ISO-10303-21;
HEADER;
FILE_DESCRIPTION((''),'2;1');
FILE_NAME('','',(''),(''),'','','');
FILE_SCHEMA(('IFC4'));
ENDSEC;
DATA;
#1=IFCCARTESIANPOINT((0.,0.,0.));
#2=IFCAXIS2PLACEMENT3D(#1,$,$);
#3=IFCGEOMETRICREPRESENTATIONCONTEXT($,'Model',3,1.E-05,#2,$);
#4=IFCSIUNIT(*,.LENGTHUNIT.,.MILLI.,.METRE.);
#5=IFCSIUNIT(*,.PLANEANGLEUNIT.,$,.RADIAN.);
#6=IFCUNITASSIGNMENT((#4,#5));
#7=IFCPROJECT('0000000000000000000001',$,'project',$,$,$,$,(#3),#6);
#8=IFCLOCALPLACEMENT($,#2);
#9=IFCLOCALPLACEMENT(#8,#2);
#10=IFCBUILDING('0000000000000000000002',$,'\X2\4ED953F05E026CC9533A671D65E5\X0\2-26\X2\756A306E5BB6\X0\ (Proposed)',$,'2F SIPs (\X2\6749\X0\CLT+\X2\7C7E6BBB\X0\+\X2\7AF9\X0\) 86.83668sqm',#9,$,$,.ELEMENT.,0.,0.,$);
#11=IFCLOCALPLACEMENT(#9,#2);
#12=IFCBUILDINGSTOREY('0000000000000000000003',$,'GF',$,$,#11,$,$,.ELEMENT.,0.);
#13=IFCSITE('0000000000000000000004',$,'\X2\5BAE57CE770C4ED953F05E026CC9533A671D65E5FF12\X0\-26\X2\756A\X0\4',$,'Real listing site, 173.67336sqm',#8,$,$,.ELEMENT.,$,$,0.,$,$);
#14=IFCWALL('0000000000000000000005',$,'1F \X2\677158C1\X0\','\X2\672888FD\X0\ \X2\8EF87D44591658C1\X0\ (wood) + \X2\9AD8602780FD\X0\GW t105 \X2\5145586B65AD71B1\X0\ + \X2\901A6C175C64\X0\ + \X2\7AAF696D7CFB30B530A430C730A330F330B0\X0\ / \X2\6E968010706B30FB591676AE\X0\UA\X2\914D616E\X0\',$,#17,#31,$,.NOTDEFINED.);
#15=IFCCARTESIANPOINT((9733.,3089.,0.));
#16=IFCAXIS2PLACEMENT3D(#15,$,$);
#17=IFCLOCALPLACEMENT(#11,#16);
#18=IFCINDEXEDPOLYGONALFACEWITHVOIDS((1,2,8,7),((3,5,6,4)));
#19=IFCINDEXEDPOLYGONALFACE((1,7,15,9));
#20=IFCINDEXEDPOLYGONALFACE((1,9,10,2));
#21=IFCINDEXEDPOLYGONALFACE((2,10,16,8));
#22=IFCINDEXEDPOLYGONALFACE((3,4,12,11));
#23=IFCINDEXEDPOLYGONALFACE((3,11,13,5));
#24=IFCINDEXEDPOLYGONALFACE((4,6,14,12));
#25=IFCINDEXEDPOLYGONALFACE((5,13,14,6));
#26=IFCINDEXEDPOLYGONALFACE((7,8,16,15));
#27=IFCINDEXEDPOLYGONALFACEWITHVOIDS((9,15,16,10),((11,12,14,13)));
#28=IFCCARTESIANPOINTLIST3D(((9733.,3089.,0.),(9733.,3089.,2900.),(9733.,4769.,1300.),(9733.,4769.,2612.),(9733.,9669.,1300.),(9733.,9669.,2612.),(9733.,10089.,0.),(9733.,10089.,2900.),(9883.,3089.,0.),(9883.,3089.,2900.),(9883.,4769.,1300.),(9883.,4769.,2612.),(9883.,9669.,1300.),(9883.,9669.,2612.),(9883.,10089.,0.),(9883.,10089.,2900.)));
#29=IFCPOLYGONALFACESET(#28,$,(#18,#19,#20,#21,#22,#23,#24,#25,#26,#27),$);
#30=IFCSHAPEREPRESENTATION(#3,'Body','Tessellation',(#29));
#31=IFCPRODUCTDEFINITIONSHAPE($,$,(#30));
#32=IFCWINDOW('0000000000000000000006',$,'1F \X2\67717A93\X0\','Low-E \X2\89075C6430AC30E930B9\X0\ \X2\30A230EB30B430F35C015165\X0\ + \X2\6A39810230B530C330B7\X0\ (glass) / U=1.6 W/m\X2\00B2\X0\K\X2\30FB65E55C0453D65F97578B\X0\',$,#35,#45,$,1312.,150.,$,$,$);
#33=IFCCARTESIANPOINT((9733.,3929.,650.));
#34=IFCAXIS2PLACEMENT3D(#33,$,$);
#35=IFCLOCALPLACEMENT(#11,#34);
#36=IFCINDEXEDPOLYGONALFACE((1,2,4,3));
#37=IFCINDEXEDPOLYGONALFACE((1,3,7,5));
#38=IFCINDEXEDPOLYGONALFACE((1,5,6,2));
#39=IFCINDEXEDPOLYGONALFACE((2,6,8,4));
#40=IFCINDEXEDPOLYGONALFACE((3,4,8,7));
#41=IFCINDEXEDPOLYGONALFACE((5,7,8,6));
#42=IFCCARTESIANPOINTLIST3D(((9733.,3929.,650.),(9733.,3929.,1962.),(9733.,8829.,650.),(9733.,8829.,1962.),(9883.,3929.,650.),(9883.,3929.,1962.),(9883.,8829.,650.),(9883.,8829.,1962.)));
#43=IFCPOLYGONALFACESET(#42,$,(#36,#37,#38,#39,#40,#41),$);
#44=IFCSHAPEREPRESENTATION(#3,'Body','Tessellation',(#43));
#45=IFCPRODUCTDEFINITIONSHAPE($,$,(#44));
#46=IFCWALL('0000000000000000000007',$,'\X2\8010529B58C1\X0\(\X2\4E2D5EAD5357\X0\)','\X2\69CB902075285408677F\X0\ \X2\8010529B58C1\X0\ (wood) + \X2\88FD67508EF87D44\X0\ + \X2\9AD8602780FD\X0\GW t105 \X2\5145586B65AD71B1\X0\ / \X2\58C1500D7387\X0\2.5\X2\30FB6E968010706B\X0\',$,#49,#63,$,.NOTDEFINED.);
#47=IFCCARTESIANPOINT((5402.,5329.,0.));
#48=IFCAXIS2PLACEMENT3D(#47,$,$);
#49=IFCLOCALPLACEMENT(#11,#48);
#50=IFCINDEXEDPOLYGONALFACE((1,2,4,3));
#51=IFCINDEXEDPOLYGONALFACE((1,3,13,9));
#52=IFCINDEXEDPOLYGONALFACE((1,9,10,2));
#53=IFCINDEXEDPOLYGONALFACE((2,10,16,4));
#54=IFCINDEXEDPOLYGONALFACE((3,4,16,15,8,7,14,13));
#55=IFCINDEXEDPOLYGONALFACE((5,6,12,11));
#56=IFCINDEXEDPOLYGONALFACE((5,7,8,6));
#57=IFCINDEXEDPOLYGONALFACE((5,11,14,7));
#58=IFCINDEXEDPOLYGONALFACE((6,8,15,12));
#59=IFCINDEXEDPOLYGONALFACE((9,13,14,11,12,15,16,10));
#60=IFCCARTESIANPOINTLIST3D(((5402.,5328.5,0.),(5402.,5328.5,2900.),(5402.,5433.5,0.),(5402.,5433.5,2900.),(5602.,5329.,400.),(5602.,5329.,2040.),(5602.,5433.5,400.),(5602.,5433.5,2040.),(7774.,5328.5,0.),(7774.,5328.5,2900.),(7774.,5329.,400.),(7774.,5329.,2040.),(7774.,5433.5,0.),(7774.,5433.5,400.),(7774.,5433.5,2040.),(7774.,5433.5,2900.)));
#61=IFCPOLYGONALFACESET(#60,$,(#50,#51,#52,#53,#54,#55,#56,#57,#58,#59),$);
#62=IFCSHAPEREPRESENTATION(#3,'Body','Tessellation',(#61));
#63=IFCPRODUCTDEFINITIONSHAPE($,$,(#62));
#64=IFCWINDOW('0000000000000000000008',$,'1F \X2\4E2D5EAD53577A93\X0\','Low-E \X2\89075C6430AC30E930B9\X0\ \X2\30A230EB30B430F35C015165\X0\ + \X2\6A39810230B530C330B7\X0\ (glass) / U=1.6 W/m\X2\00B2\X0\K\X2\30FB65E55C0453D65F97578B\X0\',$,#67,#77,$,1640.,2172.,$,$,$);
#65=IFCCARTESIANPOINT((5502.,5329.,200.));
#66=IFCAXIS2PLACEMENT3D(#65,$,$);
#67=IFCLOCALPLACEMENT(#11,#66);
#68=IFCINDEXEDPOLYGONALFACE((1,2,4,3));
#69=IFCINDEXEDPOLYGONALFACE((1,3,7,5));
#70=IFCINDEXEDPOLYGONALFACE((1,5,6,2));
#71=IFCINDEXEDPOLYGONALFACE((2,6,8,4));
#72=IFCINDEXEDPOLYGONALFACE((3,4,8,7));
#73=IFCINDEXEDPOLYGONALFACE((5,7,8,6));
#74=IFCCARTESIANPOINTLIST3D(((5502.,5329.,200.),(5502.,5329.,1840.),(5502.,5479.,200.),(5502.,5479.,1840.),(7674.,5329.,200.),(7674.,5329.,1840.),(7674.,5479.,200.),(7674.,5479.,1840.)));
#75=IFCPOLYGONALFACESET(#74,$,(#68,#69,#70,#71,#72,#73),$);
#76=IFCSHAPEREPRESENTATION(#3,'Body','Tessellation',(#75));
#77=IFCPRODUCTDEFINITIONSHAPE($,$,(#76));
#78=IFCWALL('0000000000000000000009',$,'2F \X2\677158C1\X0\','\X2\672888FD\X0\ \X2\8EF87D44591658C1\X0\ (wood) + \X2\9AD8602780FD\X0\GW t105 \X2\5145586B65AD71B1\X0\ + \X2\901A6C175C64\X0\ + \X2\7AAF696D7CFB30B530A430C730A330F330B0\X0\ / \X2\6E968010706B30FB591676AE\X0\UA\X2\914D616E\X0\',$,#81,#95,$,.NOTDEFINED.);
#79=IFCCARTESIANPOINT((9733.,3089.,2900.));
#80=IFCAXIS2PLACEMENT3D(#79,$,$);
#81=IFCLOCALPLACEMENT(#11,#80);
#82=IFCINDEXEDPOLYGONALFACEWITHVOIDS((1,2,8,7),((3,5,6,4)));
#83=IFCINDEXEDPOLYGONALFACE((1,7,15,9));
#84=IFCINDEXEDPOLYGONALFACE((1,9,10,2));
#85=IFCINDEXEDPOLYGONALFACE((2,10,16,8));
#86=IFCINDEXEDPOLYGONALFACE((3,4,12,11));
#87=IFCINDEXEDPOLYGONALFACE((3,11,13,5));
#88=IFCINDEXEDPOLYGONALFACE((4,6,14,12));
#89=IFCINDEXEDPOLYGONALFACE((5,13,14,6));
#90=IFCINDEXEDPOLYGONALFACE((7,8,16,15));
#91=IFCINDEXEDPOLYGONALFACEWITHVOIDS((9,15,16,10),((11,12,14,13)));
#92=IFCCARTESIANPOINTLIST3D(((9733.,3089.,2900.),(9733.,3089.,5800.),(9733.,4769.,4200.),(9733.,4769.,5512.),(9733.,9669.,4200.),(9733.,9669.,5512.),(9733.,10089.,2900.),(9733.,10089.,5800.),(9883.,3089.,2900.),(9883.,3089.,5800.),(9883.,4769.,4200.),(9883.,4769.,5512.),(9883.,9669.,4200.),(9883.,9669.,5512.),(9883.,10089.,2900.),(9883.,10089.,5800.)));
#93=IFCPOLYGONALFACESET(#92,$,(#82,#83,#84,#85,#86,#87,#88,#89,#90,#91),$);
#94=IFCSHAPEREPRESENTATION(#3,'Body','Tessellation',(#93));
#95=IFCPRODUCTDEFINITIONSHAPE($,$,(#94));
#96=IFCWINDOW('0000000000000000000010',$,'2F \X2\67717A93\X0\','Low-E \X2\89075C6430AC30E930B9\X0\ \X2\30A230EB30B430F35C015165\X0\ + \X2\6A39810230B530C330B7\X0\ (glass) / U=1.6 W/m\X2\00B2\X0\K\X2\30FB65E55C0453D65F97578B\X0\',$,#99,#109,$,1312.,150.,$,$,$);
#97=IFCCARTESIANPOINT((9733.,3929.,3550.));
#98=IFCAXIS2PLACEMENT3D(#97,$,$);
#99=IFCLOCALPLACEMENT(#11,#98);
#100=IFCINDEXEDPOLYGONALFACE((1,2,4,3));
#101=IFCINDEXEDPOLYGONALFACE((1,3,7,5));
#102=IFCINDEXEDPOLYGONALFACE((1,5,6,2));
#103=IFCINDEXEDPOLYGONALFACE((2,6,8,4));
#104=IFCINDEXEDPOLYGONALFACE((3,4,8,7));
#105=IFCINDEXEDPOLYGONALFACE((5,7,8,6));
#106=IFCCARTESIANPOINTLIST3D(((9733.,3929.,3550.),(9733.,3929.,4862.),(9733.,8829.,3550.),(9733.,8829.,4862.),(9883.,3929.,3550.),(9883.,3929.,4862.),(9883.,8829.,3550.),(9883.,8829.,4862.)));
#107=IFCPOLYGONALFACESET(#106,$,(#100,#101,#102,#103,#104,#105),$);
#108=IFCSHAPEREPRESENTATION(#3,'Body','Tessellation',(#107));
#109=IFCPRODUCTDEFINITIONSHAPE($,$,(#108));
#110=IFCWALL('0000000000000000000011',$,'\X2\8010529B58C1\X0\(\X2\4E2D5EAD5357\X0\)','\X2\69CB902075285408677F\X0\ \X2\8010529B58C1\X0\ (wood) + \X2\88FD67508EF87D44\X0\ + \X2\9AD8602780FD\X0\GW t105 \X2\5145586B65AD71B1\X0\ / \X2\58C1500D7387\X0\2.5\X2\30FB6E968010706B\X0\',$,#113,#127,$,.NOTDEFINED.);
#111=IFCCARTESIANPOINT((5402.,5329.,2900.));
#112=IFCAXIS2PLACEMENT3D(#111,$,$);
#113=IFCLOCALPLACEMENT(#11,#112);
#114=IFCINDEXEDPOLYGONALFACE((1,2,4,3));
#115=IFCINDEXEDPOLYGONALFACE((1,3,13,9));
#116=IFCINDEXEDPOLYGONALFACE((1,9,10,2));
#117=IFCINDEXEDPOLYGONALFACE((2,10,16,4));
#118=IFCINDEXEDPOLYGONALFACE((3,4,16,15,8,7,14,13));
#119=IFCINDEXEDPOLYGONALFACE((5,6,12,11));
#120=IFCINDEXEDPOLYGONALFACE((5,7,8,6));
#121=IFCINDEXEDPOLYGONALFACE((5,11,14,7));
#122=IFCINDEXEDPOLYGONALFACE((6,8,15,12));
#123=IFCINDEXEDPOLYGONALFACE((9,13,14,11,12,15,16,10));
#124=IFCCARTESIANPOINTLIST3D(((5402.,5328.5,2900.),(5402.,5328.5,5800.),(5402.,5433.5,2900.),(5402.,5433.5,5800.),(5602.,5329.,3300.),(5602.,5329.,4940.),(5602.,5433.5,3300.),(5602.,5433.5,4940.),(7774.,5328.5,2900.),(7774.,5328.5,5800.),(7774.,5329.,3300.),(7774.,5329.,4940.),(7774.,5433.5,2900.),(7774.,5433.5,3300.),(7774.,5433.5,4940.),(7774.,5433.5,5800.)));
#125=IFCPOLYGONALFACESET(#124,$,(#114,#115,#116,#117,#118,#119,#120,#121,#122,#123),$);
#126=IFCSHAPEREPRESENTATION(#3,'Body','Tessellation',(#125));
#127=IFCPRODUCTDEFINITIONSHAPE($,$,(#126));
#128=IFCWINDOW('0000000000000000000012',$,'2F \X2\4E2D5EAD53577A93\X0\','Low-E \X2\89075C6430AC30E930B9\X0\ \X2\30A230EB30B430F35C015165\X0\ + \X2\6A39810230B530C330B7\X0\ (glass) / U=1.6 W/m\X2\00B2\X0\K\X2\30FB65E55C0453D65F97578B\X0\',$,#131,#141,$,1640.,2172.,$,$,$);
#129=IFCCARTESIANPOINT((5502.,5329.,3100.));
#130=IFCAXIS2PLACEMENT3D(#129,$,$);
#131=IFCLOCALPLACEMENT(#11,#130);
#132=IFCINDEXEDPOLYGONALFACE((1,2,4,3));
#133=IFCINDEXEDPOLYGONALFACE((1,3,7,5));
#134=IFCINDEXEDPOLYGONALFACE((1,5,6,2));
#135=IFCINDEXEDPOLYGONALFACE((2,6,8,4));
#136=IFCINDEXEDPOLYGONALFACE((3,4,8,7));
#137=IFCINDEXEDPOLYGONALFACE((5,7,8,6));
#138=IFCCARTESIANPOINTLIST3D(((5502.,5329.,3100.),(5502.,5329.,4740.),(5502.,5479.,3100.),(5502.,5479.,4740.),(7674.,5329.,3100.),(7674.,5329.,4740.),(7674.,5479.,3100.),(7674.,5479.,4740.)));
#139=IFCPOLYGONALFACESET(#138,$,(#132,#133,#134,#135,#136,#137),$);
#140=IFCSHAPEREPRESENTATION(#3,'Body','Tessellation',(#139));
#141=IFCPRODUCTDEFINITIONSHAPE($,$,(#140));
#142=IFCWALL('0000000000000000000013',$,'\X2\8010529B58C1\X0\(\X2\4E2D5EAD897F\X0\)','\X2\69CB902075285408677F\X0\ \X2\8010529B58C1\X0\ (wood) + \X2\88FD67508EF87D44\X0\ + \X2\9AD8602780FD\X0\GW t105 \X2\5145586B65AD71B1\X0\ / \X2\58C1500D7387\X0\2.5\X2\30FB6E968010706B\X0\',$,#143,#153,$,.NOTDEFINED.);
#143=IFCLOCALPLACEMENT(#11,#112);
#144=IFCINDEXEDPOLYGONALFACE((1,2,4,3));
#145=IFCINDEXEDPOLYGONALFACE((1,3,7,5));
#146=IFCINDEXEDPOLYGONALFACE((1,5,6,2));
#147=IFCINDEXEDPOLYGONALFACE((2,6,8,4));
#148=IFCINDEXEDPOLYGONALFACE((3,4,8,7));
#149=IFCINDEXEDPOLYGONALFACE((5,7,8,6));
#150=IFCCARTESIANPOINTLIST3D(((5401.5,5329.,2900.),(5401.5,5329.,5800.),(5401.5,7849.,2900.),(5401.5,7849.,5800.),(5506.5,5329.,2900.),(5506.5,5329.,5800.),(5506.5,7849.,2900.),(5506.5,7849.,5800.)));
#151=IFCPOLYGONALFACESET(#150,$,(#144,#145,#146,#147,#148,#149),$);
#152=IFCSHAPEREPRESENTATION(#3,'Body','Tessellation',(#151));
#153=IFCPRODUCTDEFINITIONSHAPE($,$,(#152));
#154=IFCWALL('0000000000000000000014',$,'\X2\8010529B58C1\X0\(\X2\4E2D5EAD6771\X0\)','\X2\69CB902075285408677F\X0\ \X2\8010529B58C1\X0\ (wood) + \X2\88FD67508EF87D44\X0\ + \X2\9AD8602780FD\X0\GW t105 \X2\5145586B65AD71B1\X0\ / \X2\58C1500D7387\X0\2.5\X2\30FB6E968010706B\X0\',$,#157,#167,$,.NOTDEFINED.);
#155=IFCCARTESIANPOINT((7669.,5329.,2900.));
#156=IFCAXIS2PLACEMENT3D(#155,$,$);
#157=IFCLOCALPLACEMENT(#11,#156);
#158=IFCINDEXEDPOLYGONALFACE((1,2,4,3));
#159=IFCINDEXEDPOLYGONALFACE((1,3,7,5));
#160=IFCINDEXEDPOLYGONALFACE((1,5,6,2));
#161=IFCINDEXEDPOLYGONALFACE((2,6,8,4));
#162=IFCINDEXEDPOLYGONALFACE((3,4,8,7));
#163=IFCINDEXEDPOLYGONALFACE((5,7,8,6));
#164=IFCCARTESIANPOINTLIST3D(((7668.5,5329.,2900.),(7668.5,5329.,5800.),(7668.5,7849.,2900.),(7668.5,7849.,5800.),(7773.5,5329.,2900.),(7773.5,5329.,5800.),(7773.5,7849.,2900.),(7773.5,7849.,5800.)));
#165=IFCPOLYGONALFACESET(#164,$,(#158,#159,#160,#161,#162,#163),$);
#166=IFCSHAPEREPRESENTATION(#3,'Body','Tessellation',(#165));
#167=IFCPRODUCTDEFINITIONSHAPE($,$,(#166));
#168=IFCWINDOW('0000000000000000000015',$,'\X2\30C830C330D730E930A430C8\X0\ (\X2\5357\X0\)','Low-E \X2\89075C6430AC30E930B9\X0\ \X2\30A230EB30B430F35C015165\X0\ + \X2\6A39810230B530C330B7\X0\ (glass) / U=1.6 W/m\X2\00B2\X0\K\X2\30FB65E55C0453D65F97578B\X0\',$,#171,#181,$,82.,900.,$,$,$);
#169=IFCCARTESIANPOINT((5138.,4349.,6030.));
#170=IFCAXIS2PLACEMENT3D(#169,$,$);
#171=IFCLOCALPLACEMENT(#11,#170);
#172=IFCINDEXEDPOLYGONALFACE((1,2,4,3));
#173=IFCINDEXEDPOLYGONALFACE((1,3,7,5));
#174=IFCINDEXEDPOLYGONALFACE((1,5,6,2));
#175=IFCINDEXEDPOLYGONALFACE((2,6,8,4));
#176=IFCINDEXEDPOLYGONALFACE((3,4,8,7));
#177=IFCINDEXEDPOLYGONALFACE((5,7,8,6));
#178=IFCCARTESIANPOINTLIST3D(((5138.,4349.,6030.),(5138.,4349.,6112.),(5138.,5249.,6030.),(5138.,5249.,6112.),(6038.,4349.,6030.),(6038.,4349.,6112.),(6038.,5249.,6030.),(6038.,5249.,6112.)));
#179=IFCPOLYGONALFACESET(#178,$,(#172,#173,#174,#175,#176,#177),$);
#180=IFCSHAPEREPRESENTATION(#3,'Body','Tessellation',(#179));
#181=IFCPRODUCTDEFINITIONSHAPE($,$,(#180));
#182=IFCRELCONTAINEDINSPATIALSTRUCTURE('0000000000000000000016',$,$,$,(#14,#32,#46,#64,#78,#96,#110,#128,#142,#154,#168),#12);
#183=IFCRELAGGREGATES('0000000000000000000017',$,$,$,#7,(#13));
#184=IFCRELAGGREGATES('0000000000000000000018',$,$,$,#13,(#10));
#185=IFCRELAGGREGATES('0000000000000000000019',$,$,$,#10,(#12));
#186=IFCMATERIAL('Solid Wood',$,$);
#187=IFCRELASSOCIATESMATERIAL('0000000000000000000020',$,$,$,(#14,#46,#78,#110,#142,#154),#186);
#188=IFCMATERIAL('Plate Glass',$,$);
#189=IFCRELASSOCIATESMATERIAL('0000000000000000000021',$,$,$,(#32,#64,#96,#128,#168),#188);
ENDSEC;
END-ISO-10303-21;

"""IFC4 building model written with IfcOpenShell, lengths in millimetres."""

from ifc_helpers import new_model, si_unit, frame, frame_2d, origin, place, context, project, spatial, rectangle, extrude, material, element, fill, save


model = new_model("IFC4")

# Units and contexts
model_context = context("Model", 3, precision=1e-05, world=origin())
ifc_project = project(units=[si_unit("LENGTHUNIT", "METRE", prefix="MILLI"), si_unit("PLANEANGLEUNIT", "RADIAN")], contexts=[model_context])

# Site, building, storey
site_placement = place(None, origin())
site = spatial("IfcSite", under=ifc_project, at=site_placement, Name="宮城県仙台市泉区朝日２-26番4", ObjectType="Real listing site, 173.67336sqm", CompositionType="ELEMENT", RefElevation=0.0)
building_placement = place(site_placement, origin())
building = spatial("IfcBuilding", under=site, at=building_placement, Name="仙台市泉区朝日2-26番の家 (Proposed)", ObjectType="2F SIPs (杉CLT+籾殻+竹) 86.83668sqm", CompositionType="ELEMENT", ElevationOfRefHeight=0.0, ElevationOfTerrain=0.0)
storey_placement = place(building_placement, origin())
storey = spatial("IfcBuildingStorey", under=building, at=storey_placement, Name="GF", CompositionType="ELEMENT", Elevation=0.0)

# Shared definitions
ifc_material_1 = material(Name="Solid Wood")

# Walls, openings, windows
wall_1_placement = place(storey_placement, frame((9733.0, 3089.0, 0.0)))
wall_1 = element("IfcWall", 1, at=wall_1_placement, inside=storey, material=ifc_material_1, Name="1F 東壁", Description="木製 軸組外壁 (wood) + 高性能GW t105 充填断熱 + 通気層 + 窯業系サイディング / 準耐火・外皮UA配慮", PredefinedType="NOTDEFINED", context=model_context, shape_type="SweptSolid", body=[
    extrude(rectangle(XDim=150.0, YDim=7000.0, at=frame_2d((75.0, 3500.0))), frame((9733.0, 3089.0, 0.0)), (0.0, 0.0, 1.0), 2900.0),
])
opening_1_placement = place(storey_placement, frame((9733.0, 3929.0, 650.0)))
opening_1 = element("IfcOpeningElement", 2, at=opening_1_placement, cuts=wall_1, PredefinedType="NOTDEFINED", context=model_context, shape_type="SweptSolid", body=[
    extrude(rectangle(XDim=150.0, YDim=4900.0, at=frame_2d((75.0, 2450.0))), frame((9733.0, 3929.0, 650.0)), (0.0, 0.0, 1.0), 1312.0),
])
ifc_material_2 = material(Name="Plate Glass")
window_1_placement = place(storey_placement, frame((9733.0, 3929.0, 650.0)))
window_1 = element("IfcWindow", 3, at=window_1_placement, inside=storey, material=ifc_material_2, Name="1F 東窓", Description="Low-E 複層ガラス アルゴン封入 + 樹脂サッシ (glass) / U=1.6 W/m²K・日射取得型", OverallHeight=1312.0, OverallWidth=150.0, context=model_context, shape_type="SweptSolid", body=[
    extrude(rectangle(XDim=150.0, YDim=4900.0, at=frame_2d((75.0, 2450.0))), frame((9733.0, 3929.0, 650.0)), (0.0, 0.0, 1.0), 1312.0),
])
fill(opening_1, window_1)
wall_2_placement = place(storey_placement, frame((5402.0, 5329.0, 0.0)))
wall_2 = element("IfcWall", 4, at=wall_2_placement, inside=storey, material=ifc_material_1, Name="耐力壁(中庭南)", Description="構造用合板 耐力壁 (wood) + 製材軸組 + 高性能GW t105 充填断熱 / 壁倍率2.5・準耐火", PredefinedType="NOTDEFINED", context=model_context, shape_type="SweptSolid", body=[
    extrude(rectangle(XDim=2372.0, YDim=105.0, at=frame_2d((1186.0, 52.0))), frame((5402.0, 5329.0, 0.0)), (0.0, 0.0, 1.0), 2900.0),
])
opening_2_placement = place(storey_placement, frame((5502.0, 5329.0, 200.0)))
opening_2 = element("IfcOpeningElement", 5, at=opening_2_placement, cuts=wall_2, PredefinedType="NOTDEFINED", context=model_context, shape_type="SweptSolid", body=[
    extrude(rectangle(XDim=2172.0, YDim=150.0, at=frame_2d((1086.0, 75.0))), frame((5502.0, 5329.0, 200.0)), (0.0, 0.0, 1.0), 1640.0),
])
window_2_placement = place(storey_placement, frame((5502.0, 5329.0, 200.0)))
window_2 = element("IfcWindow", 6, at=window_2_placement, inside=storey, material=ifc_material_2, Name="1F 中庭南窓", Description="Low-E 複層ガラス アルゴン封入 + 樹脂サッシ (glass) / U=1.6 W/m²K・日射取得型", OverallHeight=1640.0, OverallWidth=2172.0, context=model_context, shape_type="SweptSolid", body=[
    extrude(rectangle(XDim=2172.0, YDim=150.0, at=frame_2d((1086.0, 75.0))), frame((5502.0, 5329.0, 200.0)), (0.0, 0.0, 1.0), 1640.0),
])
fill(opening_2, window_2)

# Walls, openings, windows
wall_3_placement = place(storey_placement, frame((9733.0, 3089.0, 2900.0)))
wall_3 = element("IfcWall", 7, at=wall_3_placement, inside=storey, material=ifc_material_1, Name="2F 東壁", Description="木製 軸組外壁 (wood) + 高性能GW t105 充填断熱 + 通気層 + 窯業系サイディング / 準耐火・外皮UA配慮", PredefinedType="NOTDEFINED", context=model_context, shape_type="SweptSolid", body=[
    extrude(rectangle(XDim=150.0, YDim=7000.0, at=frame_2d((75.0, 3500.0))), frame((9733.0, 3089.0, 2900.0)), (0.0, 0.0, 1.0), 2900.0),
])
opening_3_placement = place(storey_placement, frame((9733.0, 3929.0, 3550.0)))
opening_3 = element("IfcOpeningElement", 8, at=opening_3_placement, cuts=wall_3, PredefinedType="NOTDEFINED", context=model_context, shape_type="SweptSolid", body=[
    extrude(rectangle(XDim=150.0, YDim=4900.0, at=frame_2d((75.0, 2450.0))), frame((9733.0, 3929.0, 3550.0)), (0.0, 0.0, 1.0), 1312.0),
])
window_3_placement = place(storey_placement, frame((9733.0, 3929.0, 3550.0)))
window_3 = element("IfcWindow", 9, at=window_3_placement, inside=storey, material=ifc_material_2, Name="2F 東窓", Description="Low-E 複層ガラス アルゴン封入 + 樹脂サッシ (glass) / U=1.6 W/m²K・日射取得型", OverallHeight=1312.0, OverallWidth=150.0, context=model_context, shape_type="SweptSolid", body=[
    extrude(rectangle(XDim=150.0, YDim=4900.0, at=frame_2d((75.0, 2450.0))), frame((9733.0, 3929.0, 3550.0)), (0.0, 0.0, 1.0), 1312.0),
])
fill(opening_3, window_3)
wall_4_placement = place(storey_placement, frame((5402.0, 5329.0, 2900.0)))
wall_4 = element("IfcWall", 10, at=wall_4_placement, inside=storey, material=ifc_material_1, Name="耐力壁(中庭南)", Description="構造用合板 耐力壁 (wood) + 製材軸組 + 高性能GW t105 充填断熱 / 壁倍率2.5・準耐火", PredefinedType="NOTDEFINED", context=model_context, shape_type="SweptSolid", body=[
    extrude(rectangle(XDim=2372.0, YDim=105.0, at=frame_2d((1186.0, 52.0))), frame((5402.0, 5329.0, 2900.0)), (0.0, 0.0, 1.0), 2900.0),
])
opening_4_placement = place(storey_placement, frame((5502.0, 5329.0, 3100.0)))
opening_4 = element("IfcOpeningElement", 11, at=opening_4_placement, cuts=wall_4, PredefinedType="NOTDEFINED", context=model_context, shape_type="SweptSolid", body=[
    extrude(rectangle(XDim=2172.0, YDim=150.0, at=frame_2d((1086.0, 75.0))), frame((5502.0, 5329.0, 3100.0)), (0.0, 0.0, 1.0), 1640.0),
])
window_4_placement = place(storey_placement, frame((5502.0, 5329.0, 3100.0)))
window_4 = element("IfcWindow", 12, at=window_4_placement, inside=storey, material=ifc_material_2, Name="2F 中庭南窓", Description="Low-E 複層ガラス アルゴン封入 + 樹脂サッシ (glass) / U=1.6 W/m²K・日射取得型", OverallHeight=1640.0, OverallWidth=2172.0, context=model_context, shape_type="SweptSolid", body=[
    extrude(rectangle(XDim=2172.0, YDim=150.0, at=frame_2d((1086.0, 75.0))), frame((5502.0, 5329.0, 3100.0)), (0.0, 0.0, 1.0), 1640.0),
])
fill(opening_4, window_4)

# Walls
wall_5_placement = place(storey_placement, frame((5402.0, 5329.0, 2900.0)))
element("IfcWall", 13, at=wall_5_placement, inside=storey, material=ifc_material_1, Name="耐力壁(中庭西)", Description="構造用合板 耐力壁 (wood) + 製材軸組 + 高性能GW t105 充填断熱 / 壁倍率2.5・準耐火", PredefinedType="NOTDEFINED", context=model_context, shape_type="SweptSolid", body=[
    extrude(rectangle(XDim=105.0, YDim=2520.0, at=frame_2d((52.0, 1260.0))), frame((5402.0, 5329.0, 2900.0)), (0.0, 0.0, 1.0), 2900.0),
])
wall_6_placement = place(storey_placement, frame((7669.0, 5329.0, 2900.0)))
element("IfcWall", 14, at=wall_6_placement, inside=storey, material=ifc_material_1, Name="耐力壁(中庭東)", Description="構造用合板 耐力壁 (wood) + 製材軸組 + 高性能GW t105 充填断熱 / 壁倍率2.5・準耐火", PredefinedType="NOTDEFINED", context=model_context, shape_type="SweptSolid", body=[
    extrude(rectangle(XDim=105.0, YDim=2520.0, at=frame_2d((52.0, 1260.0))), frame((7669.0, 5329.0, 2900.0)), (0.0, 0.0, 1.0), 2900.0),
])

# Window
window_5_placement = place(storey_placement, frame((5138.0, 4349.0, 6030.0)))
element("IfcWindow", 15, at=window_5_placement, inside=storey, material=ifc_material_2, Name="トップライト (南)", Description="Low-E 複層ガラス アルゴン封入 + 樹脂サッシ (glass) / U=1.6 W/m²K・日射取得型", OverallHeight=82.0, OverallWidth=900.0, context=model_context, shape_type="SweptSolid", body=[
    extrude(rectangle(XDim=900.0, YDim=900.0, at=frame_2d((450.0, 450.0))), frame((5138.0, 4349.0, 6030.0)), (0.0, 0.0, 1.0), 82.0),
])

save(model, "model.ifc")
